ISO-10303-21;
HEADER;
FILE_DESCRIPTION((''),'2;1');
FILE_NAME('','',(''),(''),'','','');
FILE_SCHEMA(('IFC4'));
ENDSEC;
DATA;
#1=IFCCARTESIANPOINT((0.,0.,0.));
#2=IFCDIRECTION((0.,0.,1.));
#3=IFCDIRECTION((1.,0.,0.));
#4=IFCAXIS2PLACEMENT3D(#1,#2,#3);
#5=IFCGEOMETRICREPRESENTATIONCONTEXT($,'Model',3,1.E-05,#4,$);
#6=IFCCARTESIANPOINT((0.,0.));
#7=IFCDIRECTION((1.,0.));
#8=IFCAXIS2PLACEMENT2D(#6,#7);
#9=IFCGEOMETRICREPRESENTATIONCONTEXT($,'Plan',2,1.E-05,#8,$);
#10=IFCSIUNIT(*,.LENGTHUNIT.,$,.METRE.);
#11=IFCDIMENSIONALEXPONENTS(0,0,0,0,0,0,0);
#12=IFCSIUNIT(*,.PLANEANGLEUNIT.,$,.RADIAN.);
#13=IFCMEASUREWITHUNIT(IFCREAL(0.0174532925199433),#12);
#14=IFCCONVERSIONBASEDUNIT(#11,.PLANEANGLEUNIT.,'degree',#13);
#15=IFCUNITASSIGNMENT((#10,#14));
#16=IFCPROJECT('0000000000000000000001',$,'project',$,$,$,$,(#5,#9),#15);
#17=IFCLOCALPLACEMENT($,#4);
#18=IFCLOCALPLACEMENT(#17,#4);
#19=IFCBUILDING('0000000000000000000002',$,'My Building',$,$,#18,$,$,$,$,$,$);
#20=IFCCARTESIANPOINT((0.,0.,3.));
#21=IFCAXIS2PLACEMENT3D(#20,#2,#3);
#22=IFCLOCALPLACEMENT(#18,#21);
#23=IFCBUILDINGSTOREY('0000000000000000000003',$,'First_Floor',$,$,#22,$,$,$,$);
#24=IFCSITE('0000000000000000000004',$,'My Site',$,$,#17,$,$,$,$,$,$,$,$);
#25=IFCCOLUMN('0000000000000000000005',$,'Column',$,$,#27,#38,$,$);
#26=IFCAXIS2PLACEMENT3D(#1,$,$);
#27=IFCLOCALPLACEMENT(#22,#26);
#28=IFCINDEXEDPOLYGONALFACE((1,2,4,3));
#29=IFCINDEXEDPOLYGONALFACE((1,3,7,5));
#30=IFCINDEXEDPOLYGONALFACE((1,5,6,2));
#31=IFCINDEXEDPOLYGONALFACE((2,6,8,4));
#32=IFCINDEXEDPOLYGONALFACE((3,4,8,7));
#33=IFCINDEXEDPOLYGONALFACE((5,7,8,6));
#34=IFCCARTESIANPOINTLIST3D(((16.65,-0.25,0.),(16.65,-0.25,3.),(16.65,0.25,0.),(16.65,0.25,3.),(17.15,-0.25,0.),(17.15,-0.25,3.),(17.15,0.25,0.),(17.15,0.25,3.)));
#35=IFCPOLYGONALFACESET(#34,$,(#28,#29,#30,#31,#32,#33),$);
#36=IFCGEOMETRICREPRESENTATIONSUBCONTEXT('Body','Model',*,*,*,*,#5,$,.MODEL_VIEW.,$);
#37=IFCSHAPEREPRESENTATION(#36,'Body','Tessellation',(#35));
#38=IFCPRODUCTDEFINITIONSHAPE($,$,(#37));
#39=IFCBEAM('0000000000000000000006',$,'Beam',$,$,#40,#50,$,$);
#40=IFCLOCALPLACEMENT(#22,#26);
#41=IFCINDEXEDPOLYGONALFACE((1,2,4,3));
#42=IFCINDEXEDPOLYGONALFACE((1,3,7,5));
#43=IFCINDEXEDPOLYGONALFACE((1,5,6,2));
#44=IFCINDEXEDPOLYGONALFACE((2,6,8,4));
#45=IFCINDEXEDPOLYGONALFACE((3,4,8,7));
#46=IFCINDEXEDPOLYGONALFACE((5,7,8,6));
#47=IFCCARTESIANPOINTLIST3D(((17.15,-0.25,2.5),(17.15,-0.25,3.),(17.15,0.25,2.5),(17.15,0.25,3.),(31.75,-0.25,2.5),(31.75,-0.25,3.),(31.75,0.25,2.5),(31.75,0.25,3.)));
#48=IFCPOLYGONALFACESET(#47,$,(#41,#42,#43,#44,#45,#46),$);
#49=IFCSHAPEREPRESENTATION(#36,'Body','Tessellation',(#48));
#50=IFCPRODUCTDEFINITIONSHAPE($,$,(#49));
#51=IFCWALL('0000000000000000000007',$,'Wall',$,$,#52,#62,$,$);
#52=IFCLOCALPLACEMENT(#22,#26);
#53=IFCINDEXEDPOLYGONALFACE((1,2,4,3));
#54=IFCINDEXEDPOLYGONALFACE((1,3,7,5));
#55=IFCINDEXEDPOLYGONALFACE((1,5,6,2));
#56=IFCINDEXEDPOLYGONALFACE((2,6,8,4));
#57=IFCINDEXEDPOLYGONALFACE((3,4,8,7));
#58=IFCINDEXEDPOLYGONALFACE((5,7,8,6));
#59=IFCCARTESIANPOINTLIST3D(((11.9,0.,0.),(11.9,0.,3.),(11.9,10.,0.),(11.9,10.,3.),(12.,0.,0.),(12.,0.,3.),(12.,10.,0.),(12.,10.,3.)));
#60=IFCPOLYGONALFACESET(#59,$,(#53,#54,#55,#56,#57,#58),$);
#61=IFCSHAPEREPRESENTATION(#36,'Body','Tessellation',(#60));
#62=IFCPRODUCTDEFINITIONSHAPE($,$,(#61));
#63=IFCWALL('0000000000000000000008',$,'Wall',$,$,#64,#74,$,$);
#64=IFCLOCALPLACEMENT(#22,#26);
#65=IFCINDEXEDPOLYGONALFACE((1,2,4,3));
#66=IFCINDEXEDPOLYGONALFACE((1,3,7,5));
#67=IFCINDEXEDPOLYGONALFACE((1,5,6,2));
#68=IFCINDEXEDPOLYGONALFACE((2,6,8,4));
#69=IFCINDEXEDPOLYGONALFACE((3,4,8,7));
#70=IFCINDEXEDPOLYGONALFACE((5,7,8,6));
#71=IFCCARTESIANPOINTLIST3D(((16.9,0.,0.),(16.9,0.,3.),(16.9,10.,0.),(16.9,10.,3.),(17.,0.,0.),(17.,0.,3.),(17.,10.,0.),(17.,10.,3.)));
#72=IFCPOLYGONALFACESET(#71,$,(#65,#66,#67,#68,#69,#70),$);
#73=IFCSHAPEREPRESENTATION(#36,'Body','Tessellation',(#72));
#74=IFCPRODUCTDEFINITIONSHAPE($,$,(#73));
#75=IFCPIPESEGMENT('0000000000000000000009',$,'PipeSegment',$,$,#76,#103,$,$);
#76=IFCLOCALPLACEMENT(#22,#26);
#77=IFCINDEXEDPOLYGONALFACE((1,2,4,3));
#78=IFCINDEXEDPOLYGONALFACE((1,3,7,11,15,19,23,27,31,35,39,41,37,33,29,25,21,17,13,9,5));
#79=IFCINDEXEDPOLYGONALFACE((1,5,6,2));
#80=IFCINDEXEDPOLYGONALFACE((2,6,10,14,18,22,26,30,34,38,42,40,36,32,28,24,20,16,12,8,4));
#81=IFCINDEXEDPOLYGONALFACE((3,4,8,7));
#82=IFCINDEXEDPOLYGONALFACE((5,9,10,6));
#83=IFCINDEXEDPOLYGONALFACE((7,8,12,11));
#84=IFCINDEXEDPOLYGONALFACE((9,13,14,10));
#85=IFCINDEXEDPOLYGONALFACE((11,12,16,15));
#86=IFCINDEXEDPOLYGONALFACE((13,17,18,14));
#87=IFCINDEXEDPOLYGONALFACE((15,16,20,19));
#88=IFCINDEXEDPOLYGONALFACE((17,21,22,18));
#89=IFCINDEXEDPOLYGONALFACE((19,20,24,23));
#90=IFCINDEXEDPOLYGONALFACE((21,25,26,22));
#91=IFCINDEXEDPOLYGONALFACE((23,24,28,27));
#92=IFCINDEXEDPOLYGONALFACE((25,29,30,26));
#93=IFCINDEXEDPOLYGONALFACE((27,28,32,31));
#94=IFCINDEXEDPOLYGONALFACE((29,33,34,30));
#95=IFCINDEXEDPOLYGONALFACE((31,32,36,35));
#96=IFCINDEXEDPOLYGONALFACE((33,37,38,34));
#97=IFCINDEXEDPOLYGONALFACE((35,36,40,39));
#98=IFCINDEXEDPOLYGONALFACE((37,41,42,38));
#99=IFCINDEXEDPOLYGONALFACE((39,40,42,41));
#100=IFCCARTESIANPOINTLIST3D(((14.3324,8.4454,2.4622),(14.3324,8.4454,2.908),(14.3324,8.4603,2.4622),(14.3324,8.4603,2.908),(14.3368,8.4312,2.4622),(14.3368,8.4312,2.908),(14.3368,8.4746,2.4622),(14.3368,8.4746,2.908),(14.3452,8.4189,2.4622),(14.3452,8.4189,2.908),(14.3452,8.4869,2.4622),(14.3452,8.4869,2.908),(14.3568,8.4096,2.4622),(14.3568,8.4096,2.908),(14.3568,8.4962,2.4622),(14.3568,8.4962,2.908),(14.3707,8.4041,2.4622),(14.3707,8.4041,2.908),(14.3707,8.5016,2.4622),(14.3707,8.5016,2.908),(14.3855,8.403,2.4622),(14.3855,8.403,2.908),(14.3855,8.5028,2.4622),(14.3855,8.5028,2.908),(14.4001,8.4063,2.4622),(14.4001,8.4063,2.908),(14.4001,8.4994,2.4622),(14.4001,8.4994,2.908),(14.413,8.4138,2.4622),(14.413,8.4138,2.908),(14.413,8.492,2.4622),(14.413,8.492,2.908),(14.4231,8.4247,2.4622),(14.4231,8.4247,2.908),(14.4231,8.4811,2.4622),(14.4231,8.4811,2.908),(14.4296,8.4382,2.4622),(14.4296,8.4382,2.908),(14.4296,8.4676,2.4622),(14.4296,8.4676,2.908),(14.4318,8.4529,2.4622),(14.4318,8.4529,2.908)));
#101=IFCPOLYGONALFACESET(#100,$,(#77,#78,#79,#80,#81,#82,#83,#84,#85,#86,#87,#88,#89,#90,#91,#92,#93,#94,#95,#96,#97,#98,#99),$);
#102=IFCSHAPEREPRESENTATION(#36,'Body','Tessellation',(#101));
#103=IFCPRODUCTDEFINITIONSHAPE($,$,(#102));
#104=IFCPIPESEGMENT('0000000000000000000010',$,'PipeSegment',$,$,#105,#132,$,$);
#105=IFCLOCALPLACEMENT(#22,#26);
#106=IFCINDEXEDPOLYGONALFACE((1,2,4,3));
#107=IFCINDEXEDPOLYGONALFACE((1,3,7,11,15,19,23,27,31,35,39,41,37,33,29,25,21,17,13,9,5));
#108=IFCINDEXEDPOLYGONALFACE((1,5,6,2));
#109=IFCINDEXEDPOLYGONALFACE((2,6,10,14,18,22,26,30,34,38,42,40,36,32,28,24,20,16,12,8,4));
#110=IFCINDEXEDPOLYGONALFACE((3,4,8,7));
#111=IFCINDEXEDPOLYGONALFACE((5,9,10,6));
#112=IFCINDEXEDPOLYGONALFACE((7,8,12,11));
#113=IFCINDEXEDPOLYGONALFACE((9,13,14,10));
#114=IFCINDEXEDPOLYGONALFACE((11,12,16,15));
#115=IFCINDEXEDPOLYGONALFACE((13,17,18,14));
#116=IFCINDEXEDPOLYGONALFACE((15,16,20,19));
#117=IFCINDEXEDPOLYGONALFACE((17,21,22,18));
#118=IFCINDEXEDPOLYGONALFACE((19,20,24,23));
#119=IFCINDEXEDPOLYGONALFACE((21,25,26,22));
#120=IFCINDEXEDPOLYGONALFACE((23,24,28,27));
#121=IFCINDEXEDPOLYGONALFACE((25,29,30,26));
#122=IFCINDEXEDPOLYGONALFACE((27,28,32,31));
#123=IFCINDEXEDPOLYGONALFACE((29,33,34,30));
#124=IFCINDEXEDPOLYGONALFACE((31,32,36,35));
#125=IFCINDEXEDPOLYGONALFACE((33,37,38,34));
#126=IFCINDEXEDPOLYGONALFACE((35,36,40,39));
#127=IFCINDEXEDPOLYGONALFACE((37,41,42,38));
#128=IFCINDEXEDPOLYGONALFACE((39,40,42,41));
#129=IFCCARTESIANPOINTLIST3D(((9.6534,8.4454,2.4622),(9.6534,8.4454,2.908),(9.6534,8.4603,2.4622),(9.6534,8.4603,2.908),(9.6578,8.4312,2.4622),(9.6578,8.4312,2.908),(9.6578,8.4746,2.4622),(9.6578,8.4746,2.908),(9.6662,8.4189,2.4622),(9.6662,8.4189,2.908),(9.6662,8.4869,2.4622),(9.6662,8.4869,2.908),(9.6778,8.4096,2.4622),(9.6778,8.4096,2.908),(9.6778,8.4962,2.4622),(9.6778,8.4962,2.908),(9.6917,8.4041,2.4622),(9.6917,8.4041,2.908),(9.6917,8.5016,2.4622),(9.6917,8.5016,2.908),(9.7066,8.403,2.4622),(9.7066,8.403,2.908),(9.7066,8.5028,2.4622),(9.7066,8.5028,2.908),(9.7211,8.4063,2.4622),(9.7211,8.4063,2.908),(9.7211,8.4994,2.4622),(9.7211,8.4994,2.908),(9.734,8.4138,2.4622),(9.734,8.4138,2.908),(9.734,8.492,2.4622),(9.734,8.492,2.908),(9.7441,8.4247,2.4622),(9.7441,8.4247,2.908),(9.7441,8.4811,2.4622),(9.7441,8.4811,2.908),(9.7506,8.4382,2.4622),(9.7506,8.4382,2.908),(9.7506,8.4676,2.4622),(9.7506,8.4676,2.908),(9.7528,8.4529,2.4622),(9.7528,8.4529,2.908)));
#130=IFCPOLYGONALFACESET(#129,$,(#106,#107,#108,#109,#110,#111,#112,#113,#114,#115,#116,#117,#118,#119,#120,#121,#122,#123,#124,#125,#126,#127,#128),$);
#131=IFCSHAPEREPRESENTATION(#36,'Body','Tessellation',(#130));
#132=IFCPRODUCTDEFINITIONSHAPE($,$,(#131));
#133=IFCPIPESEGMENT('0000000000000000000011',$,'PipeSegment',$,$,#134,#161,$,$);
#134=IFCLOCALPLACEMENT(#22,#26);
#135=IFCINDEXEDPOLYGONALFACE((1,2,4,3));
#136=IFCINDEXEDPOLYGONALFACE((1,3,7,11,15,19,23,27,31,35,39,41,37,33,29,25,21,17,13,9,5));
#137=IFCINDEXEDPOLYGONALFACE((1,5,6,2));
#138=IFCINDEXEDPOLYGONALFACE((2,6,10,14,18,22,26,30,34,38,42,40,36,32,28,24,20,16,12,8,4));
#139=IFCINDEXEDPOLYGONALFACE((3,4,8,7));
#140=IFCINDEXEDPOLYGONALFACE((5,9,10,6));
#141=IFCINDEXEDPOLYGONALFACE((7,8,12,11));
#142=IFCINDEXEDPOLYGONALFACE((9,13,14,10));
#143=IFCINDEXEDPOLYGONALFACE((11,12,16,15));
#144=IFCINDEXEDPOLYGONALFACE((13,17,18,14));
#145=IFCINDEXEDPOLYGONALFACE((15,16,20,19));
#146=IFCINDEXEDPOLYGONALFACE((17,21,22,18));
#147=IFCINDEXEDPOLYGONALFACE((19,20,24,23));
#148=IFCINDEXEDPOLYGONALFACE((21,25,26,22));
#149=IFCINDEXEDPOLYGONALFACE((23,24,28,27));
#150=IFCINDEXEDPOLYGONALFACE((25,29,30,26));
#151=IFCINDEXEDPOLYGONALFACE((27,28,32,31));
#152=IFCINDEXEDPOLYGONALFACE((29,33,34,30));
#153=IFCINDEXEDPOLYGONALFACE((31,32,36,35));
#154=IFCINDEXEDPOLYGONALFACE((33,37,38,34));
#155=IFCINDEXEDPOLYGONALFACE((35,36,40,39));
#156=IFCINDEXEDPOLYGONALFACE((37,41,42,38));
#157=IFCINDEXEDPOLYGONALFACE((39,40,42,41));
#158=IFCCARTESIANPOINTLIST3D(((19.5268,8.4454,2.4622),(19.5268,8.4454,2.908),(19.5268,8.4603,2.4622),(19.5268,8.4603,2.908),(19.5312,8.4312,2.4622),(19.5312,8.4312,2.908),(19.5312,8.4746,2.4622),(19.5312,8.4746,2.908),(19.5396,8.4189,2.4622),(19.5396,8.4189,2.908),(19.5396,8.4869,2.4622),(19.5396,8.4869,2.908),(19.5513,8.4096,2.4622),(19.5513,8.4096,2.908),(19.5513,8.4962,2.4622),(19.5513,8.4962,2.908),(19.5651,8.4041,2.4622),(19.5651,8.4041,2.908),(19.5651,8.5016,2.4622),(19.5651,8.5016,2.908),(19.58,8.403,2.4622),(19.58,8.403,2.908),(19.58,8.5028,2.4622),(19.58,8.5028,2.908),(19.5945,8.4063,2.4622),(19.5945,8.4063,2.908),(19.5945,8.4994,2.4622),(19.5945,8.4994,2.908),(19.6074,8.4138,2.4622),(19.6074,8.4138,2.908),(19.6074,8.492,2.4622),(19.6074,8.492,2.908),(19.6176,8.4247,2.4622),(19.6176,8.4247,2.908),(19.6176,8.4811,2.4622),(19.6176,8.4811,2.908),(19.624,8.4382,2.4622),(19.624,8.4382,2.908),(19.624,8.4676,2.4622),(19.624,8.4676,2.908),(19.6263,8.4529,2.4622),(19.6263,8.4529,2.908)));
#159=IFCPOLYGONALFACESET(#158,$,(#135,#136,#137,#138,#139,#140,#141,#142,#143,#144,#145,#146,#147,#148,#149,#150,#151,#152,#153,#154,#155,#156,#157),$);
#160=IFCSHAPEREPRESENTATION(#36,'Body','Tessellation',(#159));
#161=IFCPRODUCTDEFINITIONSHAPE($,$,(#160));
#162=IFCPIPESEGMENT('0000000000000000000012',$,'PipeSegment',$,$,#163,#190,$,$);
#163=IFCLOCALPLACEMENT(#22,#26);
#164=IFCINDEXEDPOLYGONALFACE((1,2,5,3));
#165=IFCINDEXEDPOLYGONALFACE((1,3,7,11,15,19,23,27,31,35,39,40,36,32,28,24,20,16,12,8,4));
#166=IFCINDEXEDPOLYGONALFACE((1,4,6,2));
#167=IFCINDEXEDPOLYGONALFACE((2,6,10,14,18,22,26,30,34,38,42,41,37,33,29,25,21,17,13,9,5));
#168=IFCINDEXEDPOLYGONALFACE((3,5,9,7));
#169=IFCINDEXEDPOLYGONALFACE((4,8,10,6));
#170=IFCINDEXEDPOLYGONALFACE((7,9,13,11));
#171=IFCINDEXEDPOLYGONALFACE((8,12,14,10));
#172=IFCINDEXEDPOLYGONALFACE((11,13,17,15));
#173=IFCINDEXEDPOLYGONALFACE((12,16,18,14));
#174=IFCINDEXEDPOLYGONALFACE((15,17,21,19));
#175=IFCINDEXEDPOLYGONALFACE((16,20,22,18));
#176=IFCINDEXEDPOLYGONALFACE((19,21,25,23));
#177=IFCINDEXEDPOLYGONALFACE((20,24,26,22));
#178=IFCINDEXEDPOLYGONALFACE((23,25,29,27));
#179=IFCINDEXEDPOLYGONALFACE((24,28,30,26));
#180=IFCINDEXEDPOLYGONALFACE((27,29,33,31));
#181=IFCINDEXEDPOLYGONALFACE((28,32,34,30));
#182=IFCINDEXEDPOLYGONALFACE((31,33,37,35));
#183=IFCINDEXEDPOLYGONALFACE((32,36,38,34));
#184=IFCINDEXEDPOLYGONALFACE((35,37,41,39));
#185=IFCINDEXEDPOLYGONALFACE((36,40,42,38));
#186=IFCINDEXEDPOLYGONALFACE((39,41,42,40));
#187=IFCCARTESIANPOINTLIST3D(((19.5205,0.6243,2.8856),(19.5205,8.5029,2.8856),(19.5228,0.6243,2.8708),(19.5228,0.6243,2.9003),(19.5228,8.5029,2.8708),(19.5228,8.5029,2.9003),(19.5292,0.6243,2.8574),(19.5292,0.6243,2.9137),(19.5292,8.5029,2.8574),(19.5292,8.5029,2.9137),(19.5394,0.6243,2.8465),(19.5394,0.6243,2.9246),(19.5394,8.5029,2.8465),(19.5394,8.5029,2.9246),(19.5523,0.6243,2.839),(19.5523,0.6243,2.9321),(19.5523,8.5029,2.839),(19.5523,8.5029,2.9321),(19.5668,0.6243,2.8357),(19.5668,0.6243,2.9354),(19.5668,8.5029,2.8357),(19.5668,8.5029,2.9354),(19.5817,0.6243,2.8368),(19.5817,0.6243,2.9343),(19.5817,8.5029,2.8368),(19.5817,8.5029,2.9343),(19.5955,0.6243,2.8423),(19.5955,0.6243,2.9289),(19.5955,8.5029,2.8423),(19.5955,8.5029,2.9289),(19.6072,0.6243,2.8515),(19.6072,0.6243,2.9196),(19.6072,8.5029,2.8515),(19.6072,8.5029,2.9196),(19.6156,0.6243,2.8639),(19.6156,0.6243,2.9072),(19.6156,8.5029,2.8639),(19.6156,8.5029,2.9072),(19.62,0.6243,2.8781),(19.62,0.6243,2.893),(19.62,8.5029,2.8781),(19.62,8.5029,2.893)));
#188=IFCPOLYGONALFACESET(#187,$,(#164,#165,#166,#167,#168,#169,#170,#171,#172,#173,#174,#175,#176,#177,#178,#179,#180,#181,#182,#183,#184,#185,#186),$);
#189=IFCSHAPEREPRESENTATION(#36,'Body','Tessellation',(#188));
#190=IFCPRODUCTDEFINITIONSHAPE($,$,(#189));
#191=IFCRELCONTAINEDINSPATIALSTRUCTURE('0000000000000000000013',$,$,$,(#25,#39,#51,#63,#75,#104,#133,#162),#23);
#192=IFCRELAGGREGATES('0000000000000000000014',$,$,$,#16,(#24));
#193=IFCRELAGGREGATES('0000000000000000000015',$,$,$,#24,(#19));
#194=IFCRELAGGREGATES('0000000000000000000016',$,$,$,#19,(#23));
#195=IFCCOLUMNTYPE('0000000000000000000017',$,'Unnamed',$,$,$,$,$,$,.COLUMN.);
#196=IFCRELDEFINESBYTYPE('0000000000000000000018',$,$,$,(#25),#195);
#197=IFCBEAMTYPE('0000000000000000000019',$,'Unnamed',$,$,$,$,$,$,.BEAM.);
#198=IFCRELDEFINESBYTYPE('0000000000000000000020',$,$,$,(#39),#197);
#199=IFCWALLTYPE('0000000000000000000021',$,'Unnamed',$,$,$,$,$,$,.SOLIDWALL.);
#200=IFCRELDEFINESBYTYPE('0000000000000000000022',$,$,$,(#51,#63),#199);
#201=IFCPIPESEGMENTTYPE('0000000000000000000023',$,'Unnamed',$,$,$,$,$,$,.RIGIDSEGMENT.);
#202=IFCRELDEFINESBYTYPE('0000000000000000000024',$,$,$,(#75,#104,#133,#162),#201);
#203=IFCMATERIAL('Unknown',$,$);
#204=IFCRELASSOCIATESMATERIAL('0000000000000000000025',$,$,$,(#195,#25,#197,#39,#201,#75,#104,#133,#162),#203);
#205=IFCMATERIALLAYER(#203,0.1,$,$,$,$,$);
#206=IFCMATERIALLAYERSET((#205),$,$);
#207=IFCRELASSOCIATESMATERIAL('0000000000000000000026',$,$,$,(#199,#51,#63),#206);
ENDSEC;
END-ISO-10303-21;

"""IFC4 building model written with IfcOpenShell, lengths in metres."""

from ifc_helpers import new_model, entity, si_unit, converted_unit, frame, origin_with_axes, origin_2d_with_axis, place, context, subcontext, project, spatial, line, indexed_curve, rectangle, circle, outline, extrude, material, layer, layer_set, layer_usage, material_profile, profile_set, profile_usage, type_object, element, save


model = new_model("IFC4")

# Units and contexts
model_context = context("Model", 3, precision=1e-05, world=origin_with_axes())
plan_context = context("Plan", 2, precision=1e-05, world=origin_2d_with_axis())
body_context = subcontext(model_context, "Body", "Model", "MODEL_VIEW")
ifc_project = project(units=[si_unit("LENGTHUNIT", "METRE"), converted_unit("PLANEANGLEUNIT", "degree", entity("IfcReal", 0.0174532925199433), si_unit("PLANEANGLEUNIT", "RADIAN"), dimensions=[0, 0, 0, 0, 0, 0, 0])], contexts=[model_context, plan_context])

# Site, building, storey
site_placement = place(None, origin_with_axes())
site = spatial("IfcSite", under=ifc_project, at=site_placement, Name="My Site")
building_placement = place(site_placement, origin_with_axes())
building = spatial("IfcBuilding", under=site, at=building_placement, Name="My Building")
storey_placement = place(building_placement, frame((0.0, 0.0, 3.0), z_axis=(0.0, 0.0, 1.0), x_axis=(1.0, 0.0, 0.0)))
storey = spatial("IfcBuildingStorey", under=building, at=storey_placement, Name="First_Floor")

# Column
ifc_material = material(Name="Unknown")
ifc_material_profile_1 = material_profile(ifc_material, rectangle(XDim=0.5, YDim=0.5))
ifc_profile_set_1 = profile_set([ifc_material_profile_1])
ifc_profile_usage_1 = profile_usage(ifc_profile_set_1, cardinal=5)
column_type = type_object("IfcColumnType", Name="Unnamed", PredefinedType="COLUMN", material=ifc_profile_set_1)
column_placement = place(storey_placement, frame((16.9, 0.0, 0.0), z_axis=(0.0, 0.0, 1.0), x_axis=(1.0, 0.0, 0.0)))
element("IfcColumn", 1, at=column_placement, inside=storey, type_object=column_type, material=ifc_profile_usage_1, Name="Column", context=body_context, shape_type="SweptSolid", body=[
    extrude(rectangle(XDim=0.5, YDim=0.5), origin_with_axes(), (0.0, 0.0, 1.0), 3.0),
])

# Beam
ifc_material_profile_2 = material_profile(ifc_material, rectangle(XDim=0.5, YDim=0.5))
ifc_profile_set_2 = profile_set([ifc_material_profile_2])
ifc_profile_usage_2 = profile_usage(ifc_profile_set_2, cardinal=6)
beam_type = type_object("IfcBeamType", Name="Unnamed", PredefinedType="BEAM", material=ifc_profile_set_2)
beam_placement = place(storey_placement, frame((17.15, -0.25, 2.75), z_axis=(1.0, 0.0, 0.0), x_axis=(0.0, 1.0, 0.0)))
element("IfcBeam", 2, at=beam_placement, inside=storey, type_object=beam_type, material=ifc_profile_usage_2, Name="Beam", context=body_context, shape_type="SweptSolid", body=[
    extrude(rectangle(XDim=0.5, YDim=0.5), frame((0.25, 0.0, 0.0), z_axis=(0.0, 0.0, 1.0), x_axis=(1.0, 0.0, 0.0)), (0.0, 0.0, 1.0), 14.6),
])

# Walls
ifc_layer = layer(ifc_material, 0.1)
ifc_layer_set = layer_set([ifc_layer])
ifc_layer_usage_1 = layer_usage(ifc_layer_set, "AXIS2", "POSITIVE", 0.0)
wall_type = type_object("IfcWallType", Name="Unnamed", PredefinedType="SOLIDWALL", material=ifc_layer_set)
wall_1_placement = place(storey_placement, frame((11.9, 10.0, 0.0), z_axis=(0.0, 0.0, 1.0), x_axis=(0.0, -1.0, 0.0)))
element("IfcWall", 3, at=wall_1_placement, inside=storey, type_object=wall_type, material=ifc_layer_usage_1, Name="Wall", context=body_context, shape_type="SweptSolid", body=[
    extrude(outline(indexed_curve([(0.0, 0.0), (0.0, 0.1), (10.0, 0.1), (10.0, 0.0)], segments=[line(1, 2, 3, 4, 1)])), origin_with_axes(), (0.0, 0.0, 1.0), 3.0),
])
ifc_layer_usage_2 = layer_usage(ifc_layer_set, "AXIS2", "POSITIVE", 0.0)
wall_2_placement = place(storey_placement, frame((16.9, 10.0, 0.0), z_axis=(0.0, 0.0, 1.0), x_axis=(0.0, -1.0, 0.0)))
element("IfcWall", 4, at=wall_2_placement, inside=storey, type_object=wall_type, material=ifc_layer_usage_2, Name="Wall", context=body_context, shape_type="SweptSolid", body=[
    extrude(outline(indexed_curve([(0.0, 0.0), (0.0, 0.1), (10.0, 0.1), (10.0, 0.0)], segments=[line(1, 2, 3, 4, 1)])), origin_with_axes(), (0.0, 0.0, 1.0), 3.0),
])

# Pipe segments
ifc_material_profile_3 = material_profile(ifc_material, circle(Radius=0.05))
ifc_profile_set_3 = profile_set([ifc_material_profile_3])
ifc_profile_usage_3 = profile_usage(ifc_profile_set_3, cardinal=5)
pipe_segment_type = type_object("IfcPipeSegmentType", Name="Unnamed", PredefinedType="RIGIDSEGMENT", material=ifc_profile_set_3)
pipe_segment_1_placement = place(storey_placement, frame((14.3818, 8.4529, 2.908), z_axis=(0.0, 0.0, -1.0), x_axis=(1.0, 0.0, 0.0)))
element("IfcPipeSegment", 5, at=pipe_segment_1_placement, inside=storey, type_object=pipe_segment_type, material=ifc_profile_usage_3, Name="PipeSegment", context=body_context, shape_type="SweptSolid", body=[
    extrude(circle(Radius=0.05), origin_with_axes(), (0.0, 0.0, 1.0), 0.4458),
])
ifc_profile_usage_4 = profile_usage(ifc_profile_set_3, cardinal=5)
pipe_segment_2_placement = place(storey_placement, frame((9.7028, 8.4529, 2.908), z_axis=(0.0, 0.0, -1.0), x_axis=(1.0, 0.0, 0.0)))
element("IfcPipeSegment", 6, at=pipe_segment_2_placement, inside=storey, type_object=pipe_segment_type, material=ifc_profile_usage_4, Name="PipeSegment", context=body_context, shape_type="SweptSolid", body=[
    extrude(circle(Radius=0.05), origin_with_axes(), (0.0, 0.0, 1.0), 0.4458),
])
ifc_profile_usage_5 = profile_usage(ifc_profile_set_3, cardinal=5)
pipe_segment_3_placement = place(storey_placement, frame((19.5763, 8.4529, 2.908), z_axis=(0.0, 0.0, -1.0), x_axis=(1.0, 0.0, 0.0)))
element("IfcPipeSegment", 7, at=pipe_segment_3_placement, inside=storey, type_object=pipe_segment_type, material=ifc_profile_usage_5, Name="PipeSegment", context=body_context, shape_type="SweptSolid", body=[
    extrude(circle(Radius=0.05), origin_with_axes(), (0.0, 0.0, 1.0), 0.4458),
])
ifc_profile_usage_6 = profile_usage(ifc_profile_set_3, cardinal=5)
pipe_segment_4_placement = place(storey_placement, frame((19.5705, 0.6243, 2.8856), z_axis=(0.0, 1.0, 0.0), x_axis=(-1.0, 0.0, 0.0)))
element("IfcPipeSegment", 8, at=pipe_segment_4_placement, inside=storey, type_object=pipe_segment_type, material=ifc_profile_usage_6, Name="PipeSegment", context=body_context, shape_type="SweptSolid", body=[
    extrude(circle(Radius=0.05), origin_with_axes(), (0.0, 0.0, 1.0), 7.8786),
])

save(model, "model.ifc")
